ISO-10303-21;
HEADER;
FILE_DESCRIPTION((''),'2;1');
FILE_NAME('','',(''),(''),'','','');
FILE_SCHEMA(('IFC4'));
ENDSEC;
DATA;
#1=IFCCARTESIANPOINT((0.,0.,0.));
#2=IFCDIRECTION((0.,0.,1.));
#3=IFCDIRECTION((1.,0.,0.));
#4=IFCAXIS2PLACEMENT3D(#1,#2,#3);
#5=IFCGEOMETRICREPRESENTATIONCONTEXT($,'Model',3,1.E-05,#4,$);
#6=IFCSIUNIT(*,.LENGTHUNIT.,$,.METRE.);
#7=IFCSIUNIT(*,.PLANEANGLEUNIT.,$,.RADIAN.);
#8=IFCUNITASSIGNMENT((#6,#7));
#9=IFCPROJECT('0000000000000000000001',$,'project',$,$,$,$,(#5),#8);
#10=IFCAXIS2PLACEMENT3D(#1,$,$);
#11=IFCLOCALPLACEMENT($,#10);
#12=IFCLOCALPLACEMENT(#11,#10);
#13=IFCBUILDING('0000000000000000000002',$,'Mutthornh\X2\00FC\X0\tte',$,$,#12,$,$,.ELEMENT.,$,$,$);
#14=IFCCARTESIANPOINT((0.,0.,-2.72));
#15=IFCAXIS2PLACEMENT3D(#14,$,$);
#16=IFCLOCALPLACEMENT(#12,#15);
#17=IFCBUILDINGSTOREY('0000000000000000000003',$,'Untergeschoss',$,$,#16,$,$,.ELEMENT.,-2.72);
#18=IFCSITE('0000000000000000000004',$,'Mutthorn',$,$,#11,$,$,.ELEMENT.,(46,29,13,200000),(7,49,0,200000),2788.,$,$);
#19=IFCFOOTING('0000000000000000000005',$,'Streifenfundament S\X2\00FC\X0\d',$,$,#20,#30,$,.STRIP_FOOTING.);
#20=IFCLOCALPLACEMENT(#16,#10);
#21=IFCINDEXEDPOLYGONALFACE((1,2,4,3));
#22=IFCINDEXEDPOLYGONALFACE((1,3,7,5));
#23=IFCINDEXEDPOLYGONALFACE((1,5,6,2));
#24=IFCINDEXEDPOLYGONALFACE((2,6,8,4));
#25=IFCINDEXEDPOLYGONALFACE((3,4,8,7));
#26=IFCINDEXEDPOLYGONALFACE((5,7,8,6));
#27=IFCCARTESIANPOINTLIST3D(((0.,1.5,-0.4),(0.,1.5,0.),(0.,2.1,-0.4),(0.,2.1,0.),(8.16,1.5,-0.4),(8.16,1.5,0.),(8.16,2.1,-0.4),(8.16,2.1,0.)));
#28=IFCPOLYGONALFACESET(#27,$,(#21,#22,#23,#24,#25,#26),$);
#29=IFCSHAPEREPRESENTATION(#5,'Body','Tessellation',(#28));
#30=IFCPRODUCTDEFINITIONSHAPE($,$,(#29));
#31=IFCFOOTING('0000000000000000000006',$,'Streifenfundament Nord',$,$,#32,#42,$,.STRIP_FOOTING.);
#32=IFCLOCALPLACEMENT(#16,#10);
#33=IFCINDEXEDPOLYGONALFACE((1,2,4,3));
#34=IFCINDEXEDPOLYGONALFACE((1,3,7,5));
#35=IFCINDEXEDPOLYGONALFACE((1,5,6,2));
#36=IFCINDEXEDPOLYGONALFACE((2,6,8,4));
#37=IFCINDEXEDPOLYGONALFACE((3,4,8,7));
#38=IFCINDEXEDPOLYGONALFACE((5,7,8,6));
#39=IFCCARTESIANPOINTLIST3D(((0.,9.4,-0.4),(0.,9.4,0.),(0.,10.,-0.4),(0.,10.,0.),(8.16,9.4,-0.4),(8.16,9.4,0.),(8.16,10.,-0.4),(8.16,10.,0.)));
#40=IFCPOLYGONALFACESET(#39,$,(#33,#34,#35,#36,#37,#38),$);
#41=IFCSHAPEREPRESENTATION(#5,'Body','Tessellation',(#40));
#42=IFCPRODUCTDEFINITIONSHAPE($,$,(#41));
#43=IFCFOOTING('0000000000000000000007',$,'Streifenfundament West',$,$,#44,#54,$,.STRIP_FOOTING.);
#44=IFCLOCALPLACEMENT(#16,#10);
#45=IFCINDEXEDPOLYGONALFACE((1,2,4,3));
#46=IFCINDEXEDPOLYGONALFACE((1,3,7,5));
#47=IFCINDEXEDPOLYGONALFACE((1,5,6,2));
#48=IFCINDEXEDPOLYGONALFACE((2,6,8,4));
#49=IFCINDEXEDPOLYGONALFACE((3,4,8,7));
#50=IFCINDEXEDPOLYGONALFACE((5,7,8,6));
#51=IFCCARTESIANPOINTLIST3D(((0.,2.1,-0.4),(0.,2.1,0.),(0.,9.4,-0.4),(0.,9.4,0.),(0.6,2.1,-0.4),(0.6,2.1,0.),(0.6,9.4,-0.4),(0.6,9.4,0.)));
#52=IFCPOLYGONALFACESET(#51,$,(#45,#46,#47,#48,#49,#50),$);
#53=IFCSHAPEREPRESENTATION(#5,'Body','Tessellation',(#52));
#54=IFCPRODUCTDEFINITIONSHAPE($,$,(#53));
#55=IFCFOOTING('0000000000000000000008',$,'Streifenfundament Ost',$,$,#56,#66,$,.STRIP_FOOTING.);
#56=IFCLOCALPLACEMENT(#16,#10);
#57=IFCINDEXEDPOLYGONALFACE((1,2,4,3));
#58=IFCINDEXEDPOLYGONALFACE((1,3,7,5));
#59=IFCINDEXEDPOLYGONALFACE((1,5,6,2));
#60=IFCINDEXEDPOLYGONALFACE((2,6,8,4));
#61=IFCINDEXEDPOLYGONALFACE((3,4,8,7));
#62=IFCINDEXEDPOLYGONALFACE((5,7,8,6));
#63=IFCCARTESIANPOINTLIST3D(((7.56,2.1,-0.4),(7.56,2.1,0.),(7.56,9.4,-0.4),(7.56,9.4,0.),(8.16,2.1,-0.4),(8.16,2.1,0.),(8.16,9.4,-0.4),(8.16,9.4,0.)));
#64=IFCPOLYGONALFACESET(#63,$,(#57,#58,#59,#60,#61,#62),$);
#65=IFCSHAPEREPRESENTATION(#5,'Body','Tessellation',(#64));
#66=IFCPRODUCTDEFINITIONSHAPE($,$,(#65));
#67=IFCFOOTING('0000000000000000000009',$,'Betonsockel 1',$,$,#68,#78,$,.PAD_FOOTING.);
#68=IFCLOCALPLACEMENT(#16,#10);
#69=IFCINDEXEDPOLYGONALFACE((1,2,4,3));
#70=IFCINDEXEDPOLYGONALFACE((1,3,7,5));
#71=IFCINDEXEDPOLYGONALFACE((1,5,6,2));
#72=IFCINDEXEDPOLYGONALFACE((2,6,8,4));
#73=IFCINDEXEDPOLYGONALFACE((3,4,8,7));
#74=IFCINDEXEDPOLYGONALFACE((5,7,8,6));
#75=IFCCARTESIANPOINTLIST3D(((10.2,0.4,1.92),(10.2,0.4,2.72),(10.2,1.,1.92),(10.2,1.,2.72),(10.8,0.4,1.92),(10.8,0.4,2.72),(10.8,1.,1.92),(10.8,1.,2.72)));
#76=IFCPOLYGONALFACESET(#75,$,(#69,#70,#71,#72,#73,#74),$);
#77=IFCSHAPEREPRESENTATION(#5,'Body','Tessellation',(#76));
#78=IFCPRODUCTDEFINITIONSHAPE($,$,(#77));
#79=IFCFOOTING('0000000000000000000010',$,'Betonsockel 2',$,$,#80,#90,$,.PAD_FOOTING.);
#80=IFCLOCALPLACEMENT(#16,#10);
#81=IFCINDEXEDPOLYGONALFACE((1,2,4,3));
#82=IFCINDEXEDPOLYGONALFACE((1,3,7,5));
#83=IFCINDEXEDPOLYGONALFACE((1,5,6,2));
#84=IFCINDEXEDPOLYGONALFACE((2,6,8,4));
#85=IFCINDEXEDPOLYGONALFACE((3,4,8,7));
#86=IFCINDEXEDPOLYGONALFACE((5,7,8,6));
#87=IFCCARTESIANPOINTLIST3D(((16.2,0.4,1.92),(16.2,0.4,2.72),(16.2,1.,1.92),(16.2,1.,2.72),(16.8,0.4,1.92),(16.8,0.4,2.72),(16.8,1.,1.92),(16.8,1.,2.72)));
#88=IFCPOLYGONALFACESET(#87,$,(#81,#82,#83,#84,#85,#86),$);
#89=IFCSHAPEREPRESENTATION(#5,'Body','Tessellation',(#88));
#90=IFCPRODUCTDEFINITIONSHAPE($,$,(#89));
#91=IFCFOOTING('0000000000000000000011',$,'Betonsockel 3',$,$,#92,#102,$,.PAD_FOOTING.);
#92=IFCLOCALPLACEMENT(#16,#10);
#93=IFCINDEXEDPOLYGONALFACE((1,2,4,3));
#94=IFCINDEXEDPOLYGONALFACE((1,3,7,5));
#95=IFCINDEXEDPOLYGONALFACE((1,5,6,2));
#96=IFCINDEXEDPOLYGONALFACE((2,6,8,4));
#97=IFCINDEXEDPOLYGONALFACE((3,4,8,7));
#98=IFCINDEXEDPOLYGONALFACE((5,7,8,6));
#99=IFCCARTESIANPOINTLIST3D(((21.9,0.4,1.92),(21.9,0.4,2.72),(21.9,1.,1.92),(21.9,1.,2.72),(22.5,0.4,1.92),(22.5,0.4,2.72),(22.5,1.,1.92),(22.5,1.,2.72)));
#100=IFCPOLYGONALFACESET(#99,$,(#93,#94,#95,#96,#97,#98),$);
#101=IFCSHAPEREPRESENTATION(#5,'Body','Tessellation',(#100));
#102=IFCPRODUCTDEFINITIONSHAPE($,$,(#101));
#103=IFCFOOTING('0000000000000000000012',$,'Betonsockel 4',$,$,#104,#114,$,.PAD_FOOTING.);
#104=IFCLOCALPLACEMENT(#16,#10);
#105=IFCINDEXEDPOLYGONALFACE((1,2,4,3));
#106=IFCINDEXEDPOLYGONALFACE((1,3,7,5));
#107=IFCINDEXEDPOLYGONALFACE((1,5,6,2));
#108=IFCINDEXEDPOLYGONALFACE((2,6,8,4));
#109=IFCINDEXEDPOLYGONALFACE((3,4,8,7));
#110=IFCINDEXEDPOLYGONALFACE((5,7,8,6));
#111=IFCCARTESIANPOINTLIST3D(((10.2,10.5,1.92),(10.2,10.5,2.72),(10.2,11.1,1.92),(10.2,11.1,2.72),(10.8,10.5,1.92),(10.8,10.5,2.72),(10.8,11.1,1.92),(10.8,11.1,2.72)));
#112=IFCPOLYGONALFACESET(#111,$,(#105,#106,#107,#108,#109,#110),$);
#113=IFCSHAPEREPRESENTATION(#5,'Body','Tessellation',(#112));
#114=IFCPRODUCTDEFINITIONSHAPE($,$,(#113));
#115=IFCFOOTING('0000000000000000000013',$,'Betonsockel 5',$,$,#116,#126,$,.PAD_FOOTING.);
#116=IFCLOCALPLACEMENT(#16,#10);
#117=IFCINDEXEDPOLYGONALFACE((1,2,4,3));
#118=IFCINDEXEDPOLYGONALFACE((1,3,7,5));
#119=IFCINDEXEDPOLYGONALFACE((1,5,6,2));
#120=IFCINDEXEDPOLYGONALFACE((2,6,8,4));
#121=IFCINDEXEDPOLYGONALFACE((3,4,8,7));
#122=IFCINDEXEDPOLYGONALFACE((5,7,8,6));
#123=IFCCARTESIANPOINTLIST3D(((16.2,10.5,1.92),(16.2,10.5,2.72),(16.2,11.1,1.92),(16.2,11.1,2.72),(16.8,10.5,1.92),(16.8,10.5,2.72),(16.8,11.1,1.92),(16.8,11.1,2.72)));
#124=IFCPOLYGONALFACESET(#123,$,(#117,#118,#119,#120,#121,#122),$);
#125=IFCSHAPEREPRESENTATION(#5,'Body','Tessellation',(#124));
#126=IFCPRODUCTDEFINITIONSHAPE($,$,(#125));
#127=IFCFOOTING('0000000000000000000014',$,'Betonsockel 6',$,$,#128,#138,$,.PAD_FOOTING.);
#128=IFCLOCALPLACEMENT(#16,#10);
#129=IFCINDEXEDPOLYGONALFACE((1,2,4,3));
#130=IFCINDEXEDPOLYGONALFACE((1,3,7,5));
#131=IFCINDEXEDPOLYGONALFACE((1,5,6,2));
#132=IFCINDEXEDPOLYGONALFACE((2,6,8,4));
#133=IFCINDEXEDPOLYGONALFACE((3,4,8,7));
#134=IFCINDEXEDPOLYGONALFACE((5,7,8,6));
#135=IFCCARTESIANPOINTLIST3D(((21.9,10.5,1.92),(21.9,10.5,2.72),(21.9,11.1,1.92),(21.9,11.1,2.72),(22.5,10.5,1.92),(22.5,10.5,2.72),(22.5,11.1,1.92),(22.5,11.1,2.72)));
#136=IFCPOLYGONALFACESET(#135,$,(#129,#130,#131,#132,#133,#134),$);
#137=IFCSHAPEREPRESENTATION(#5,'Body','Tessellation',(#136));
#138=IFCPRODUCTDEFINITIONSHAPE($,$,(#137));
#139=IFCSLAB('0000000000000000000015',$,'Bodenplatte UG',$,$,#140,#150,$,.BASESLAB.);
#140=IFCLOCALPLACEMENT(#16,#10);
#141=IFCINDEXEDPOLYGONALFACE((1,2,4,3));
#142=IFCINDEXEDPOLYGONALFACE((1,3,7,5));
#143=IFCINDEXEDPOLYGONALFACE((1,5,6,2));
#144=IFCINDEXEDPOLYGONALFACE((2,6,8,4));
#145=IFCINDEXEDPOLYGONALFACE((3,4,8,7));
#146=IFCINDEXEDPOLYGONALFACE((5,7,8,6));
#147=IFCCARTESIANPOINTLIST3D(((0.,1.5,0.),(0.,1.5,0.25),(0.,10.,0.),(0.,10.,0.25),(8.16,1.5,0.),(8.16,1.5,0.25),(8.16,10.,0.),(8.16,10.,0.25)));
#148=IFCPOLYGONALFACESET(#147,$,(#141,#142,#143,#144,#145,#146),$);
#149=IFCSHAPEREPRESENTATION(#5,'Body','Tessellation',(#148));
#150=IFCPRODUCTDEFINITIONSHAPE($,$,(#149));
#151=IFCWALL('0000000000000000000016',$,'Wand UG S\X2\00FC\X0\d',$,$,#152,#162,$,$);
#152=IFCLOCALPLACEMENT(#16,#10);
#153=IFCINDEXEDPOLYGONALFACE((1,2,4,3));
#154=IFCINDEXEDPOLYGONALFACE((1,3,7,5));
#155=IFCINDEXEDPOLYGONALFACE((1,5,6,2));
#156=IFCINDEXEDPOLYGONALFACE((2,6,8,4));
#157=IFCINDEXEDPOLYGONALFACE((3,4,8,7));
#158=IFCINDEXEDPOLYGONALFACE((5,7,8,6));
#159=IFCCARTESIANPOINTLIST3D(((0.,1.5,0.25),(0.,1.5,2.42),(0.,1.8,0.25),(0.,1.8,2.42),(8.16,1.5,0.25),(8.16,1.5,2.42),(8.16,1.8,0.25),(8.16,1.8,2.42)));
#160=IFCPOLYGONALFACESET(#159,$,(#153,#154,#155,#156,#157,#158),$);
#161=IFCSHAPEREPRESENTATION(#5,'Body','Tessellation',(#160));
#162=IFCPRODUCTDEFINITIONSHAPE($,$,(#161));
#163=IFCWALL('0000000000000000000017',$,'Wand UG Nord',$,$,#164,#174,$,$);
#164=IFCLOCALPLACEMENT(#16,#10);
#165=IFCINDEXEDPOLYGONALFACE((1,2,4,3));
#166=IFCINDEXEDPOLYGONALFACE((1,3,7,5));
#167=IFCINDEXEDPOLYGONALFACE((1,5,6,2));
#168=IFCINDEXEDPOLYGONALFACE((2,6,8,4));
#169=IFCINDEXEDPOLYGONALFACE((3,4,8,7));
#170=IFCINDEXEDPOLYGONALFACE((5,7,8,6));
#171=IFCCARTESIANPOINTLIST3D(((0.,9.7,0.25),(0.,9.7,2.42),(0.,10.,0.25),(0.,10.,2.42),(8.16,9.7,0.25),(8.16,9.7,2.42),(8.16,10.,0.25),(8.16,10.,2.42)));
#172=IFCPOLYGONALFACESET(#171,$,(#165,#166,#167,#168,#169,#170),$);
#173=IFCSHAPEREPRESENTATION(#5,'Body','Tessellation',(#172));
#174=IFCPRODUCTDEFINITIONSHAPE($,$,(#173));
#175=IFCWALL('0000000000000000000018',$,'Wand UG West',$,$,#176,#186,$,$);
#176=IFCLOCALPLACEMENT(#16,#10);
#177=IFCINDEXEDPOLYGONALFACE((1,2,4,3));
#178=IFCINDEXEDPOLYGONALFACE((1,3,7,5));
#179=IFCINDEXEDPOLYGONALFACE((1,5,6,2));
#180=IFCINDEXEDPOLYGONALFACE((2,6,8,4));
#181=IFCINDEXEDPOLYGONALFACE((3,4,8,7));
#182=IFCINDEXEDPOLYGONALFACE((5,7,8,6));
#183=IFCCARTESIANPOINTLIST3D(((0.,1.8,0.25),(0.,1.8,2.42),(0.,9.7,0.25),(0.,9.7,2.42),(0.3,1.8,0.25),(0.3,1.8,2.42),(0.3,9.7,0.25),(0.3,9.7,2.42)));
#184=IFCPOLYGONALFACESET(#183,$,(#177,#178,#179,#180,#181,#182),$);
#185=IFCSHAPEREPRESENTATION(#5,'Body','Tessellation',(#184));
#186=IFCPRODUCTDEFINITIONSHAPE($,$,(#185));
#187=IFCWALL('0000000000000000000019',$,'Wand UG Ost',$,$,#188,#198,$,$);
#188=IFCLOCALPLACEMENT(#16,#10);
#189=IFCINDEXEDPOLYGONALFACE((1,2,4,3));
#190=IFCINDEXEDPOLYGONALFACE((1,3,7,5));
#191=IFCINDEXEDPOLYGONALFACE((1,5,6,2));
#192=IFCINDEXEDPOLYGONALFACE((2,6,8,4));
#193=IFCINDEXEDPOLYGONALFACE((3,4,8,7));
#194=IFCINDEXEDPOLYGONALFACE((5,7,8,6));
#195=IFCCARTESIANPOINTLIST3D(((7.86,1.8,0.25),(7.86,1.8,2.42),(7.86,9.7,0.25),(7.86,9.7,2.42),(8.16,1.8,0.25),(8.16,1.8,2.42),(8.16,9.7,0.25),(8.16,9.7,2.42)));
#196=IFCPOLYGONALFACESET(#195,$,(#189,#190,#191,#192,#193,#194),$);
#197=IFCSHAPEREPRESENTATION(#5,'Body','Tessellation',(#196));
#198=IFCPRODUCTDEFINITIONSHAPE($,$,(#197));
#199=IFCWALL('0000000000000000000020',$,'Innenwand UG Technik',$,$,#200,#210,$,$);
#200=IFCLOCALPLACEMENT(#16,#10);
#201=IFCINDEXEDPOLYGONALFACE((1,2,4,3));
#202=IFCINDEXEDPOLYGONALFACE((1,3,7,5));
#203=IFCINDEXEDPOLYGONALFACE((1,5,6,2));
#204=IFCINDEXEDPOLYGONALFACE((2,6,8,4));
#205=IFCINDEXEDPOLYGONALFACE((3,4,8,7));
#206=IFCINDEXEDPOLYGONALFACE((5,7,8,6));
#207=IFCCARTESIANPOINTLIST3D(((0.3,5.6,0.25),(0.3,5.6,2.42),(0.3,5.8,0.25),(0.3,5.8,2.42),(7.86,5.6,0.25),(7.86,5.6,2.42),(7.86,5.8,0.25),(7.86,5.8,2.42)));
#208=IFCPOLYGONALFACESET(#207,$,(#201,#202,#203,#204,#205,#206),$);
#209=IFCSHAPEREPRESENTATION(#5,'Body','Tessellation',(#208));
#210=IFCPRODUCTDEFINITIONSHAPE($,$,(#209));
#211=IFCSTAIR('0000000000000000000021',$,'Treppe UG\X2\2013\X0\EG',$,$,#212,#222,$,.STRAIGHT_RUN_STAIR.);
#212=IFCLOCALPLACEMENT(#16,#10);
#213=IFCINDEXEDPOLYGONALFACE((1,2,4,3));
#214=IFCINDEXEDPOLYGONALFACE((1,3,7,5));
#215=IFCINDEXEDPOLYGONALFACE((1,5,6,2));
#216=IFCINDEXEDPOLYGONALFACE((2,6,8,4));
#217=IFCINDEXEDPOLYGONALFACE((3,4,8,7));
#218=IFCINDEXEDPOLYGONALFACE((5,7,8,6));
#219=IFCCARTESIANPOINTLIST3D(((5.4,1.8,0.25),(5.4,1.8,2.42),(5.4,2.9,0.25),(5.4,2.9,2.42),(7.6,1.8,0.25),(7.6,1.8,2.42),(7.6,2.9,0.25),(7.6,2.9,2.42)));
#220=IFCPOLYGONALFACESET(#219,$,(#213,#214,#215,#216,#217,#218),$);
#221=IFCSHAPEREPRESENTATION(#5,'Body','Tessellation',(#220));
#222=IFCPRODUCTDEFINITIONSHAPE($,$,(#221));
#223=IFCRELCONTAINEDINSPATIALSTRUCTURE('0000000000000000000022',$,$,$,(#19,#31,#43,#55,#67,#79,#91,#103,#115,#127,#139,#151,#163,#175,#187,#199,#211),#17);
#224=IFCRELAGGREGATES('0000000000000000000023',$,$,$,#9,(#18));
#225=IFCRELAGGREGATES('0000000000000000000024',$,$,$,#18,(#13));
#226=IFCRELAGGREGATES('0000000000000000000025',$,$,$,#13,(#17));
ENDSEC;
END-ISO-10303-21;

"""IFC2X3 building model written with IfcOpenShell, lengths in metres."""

from ifc_helpers import new_model, si_unit, frame, frame_2d, origin, origin_with_axes, place, context, project, spatial, rectangle, extrude, element, save


model = new_model("IFC2X3")

# Units and contexts
model_context = context("Model", 3, precision=1e-05, world=origin_with_axes())
ifc_project = project(units=[si_unit("LENGTHUNIT", "METRE"), si_unit("PLANEANGLEUNIT", "RADIAN")], contexts=[model_context])

# Site, building, storey
site_placement = place(None, origin())
site = spatial("IfcSite", under=ifc_project, at=site_placement, Name="Mutthorn", CompositionType="ELEMENT", RefLatitude=(46, 29, 13, 200000), RefLongitude=(7, 49, 0, 200000), RefElevation=2788.0)
building_placement = place(site_placement, origin())
building = spatial("IfcBuilding", under=site, at=building_placement, Name="Mutthornhütte", CompositionType="ELEMENT")
storey_placement = place(building_placement, frame((0.0, 0.0, -2.72)))
storey = spatial("IfcBuildingStorey", under=building, at=storey_placement, Name="Untergeschoss", CompositionType="ELEMENT", Elevation=-2.72)

# Footings
footing_1_placement = place(storey_placement, origin())
element("IfcFooting", 1, at=footing_1_placement, inside=storey, Name="Streifenfundament Süd", PredefinedType="STRIP_FOOTING", context=model_context, shape_type="SweptSolid", body=[
    extrude(rectangle(XDim=8.16, YDim=0.6, at=frame_2d((4.08, 0.3))), frame((0.0, 1.5, -0.4)), (0.0, 0.0, 1.0), 0.4),
])
footing_2_placement = place(storey_placement, origin())
element("IfcFooting", 2, at=footing_2_placement, inside=storey, Name="Streifenfundament Nord", PredefinedType="STRIP_FOOTING", context=model_context, shape_type="SweptSolid", body=[
    extrude(rectangle(XDim=8.16, YDim=0.6, at=frame_2d((4.08, 0.3))), frame((0.0, 9.4, -0.4)), (0.0, 0.0, 1.0), 0.4),
])
footing_3_placement = place(storey_placement, origin())
element("IfcFooting", 3, at=footing_3_placement, inside=storey, Name="Streifenfundament West", PredefinedType="STRIP_FOOTING", context=model_context, shape_type="SweptSolid", body=[
    extrude(rectangle(XDim=0.6, YDim=7.3, at=frame_2d((0.3, 3.65))), frame((0.0, 2.1, -0.4)), (0.0, 0.0, 1.0), 0.4),
])
footing_4_placement = place(storey_placement, origin())
element("IfcFooting", 4, at=footing_4_placement, inside=storey, Name="Streifenfundament Ost", PredefinedType="STRIP_FOOTING", context=model_context, shape_type="SweptSolid", body=[
    extrude(rectangle(XDim=0.6, YDim=7.3, at=frame_2d((0.3, 3.65))), frame((7.56, 2.1, -0.4)), (0.0, 0.0, 1.0), 0.4),
])
footing_5_placement = place(storey_placement, origin())
element("IfcFooting", 5, at=footing_5_placement, inside=storey, Name="Betonsockel 1", PredefinedType="PAD_FOOTING", context=model_context, shape_type="SweptSolid", body=[
    extrude(rectangle(XDim=0.6, YDim=0.6, at=frame_2d((0.3, 0.3))), frame((10.2, 0.4, 1.92)), (0.0, 0.0, 1.0), 0.8),
])
footing_6_placement = place(storey_placement, origin())
element("IfcFooting", 6, at=footing_6_placement, inside=storey, Name="Betonsockel 2", PredefinedType="PAD_FOOTING", context=model_context, shape_type="SweptSolid", body=[
    extrude(rectangle(XDim=0.6, YDim=0.6, at=frame_2d((0.3, 0.3))), frame((16.2, 0.4, 1.92)), (0.0, 0.0, 1.0), 0.8),
])
footing_7_placement = place(storey_placement, origin())
element("IfcFooting", 7, at=footing_7_placement, inside=storey, Name="Betonsockel 3", PredefinedType="PAD_FOOTING", context=model_context, shape_type="SweptSolid", body=[
    extrude(rectangle(XDim=0.6, YDim=0.6, at=frame_2d((0.3, 0.3))), frame((21.9, 0.4, 1.92)), (0.0, 0.0, 1.0), 0.8),
])
footing_8_placement = place(storey_placement, origin())
element("IfcFooting", 8, at=footing_8_placement, inside=storey, Name="Betonsockel 4", PredefinedType="PAD_FOOTING", context=model_context, shape_type="SweptSolid", body=[
    extrude(rectangle(XDim=0.6, YDim=0.6, at=frame_2d((0.3, 0.3))), frame((10.2, 10.5, 1.92)), (0.0, 0.0, 1.0), 0.8),
])
footing_9_placement = place(storey_placement, origin())
element("IfcFooting", 9, at=footing_9_placement, inside=storey, Name="Betonsockel 5", PredefinedType="PAD_FOOTING", context=model_context, shape_type="SweptSolid", body=[
    extrude(rectangle(XDim=0.6, YDim=0.6, at=frame_2d((0.3, 0.3))), frame((16.2, 10.5, 1.92)), (0.0, 0.0, 1.0), 0.8),
])
footing_10_placement = place(storey_placement, origin())
element("IfcFooting", 10, at=footing_10_placement, inside=storey, Name="Betonsockel 6", PredefinedType="PAD_FOOTING", context=model_context, shape_type="SweptSolid", body=[
    extrude(rectangle(XDim=0.6, YDim=0.6, at=frame_2d((0.3, 0.3))), frame((21.9, 10.5, 1.92)), (0.0, 0.0, 1.0), 0.8),
])

# Slab
slab_placement = place(storey_placement, origin())
element("IfcSlab", 11, at=slab_placement, inside=storey, Name="Bodenplatte UG", PredefinedType="BASESLAB", context=model_context, shape_type="SweptSolid", body=[
    extrude(rectangle(XDim=8.16, YDim=8.5, at=frame_2d((4.08, 4.25))), frame((0.0, 1.5, 0.0)), (0.0, 0.0, 1.0), 0.25),
])

# Walls
wall_1_placement = place(storey_placement, origin())
element("IfcWall", 12, at=wall_1_placement, inside=storey, Name="Wand UG Süd", context=model_context, shape_type="SweptSolid", body=[
    extrude(rectangle(XDim=8.16, YDim=0.3, at=frame_2d((4.08, 0.15))), frame((0.0, 1.5, 0.25)), (0.0, 0.0, 1.0), 2.17),
])
wall_2_placement = place(storey_placement, origin())
element("IfcWall", 13, at=wall_2_placement, inside=storey, Name="Wand UG Nord", context=model_context, shape_type="SweptSolid", body=[
    extrude(rectangle(XDim=8.16, YDim=0.3, at=frame_2d((4.08, 0.15))), frame((0.0, 9.7, 0.25)), (0.0, 0.0, 1.0), 2.17),
])
wall_3_placement = place(storey_placement, origin())
element("IfcWall", 14, at=wall_3_placement, inside=storey, Name="Wand UG West", context=model_context, shape_type="SweptSolid", body=[
    extrude(rectangle(XDim=0.3, YDim=7.9, at=frame_2d((0.15, 3.95))), frame((0.0, 1.8, 0.25)), (0.0, 0.0, 1.0), 2.17),
])
wall_4_placement = place(storey_placement, origin())
element("IfcWall", 15, at=wall_4_placement, inside=storey, Name="Wand UG Ost", context=model_context, shape_type="SweptSolid", body=[
    extrude(rectangle(XDim=0.3, YDim=7.9, at=frame_2d((0.15, 3.95))), frame((7.86, 1.8, 0.25)), (0.0, 0.0, 1.0), 2.17),
])
wall_5_placement = place(storey_placement, origin())
element("IfcWall", 16, at=wall_5_placement, inside=storey, Name="Innenwand UG Technik", context=model_context, shape_type="SweptSolid", body=[
    extrude(rectangle(XDim=7.56, YDim=0.2, at=frame_2d((3.78, 0.1))), frame((0.3, 5.6, 0.25)), (0.0, 0.0, 1.0), 2.17),
])

# Stair
stair_placement = place(storey_placement, origin())
element("IfcStair", 17, at=stair_placement, inside=storey, Name="Treppe UG–EG", ShapeType="STRAIGHT_RUN_STAIR", context=model_context, shape_type="SweptSolid", body=[
    extrude(rectangle(XDim=2.2, YDim=1.1, at=frame_2d((1.1, 0.55))), frame((5.4, 1.8, 0.25)), (0.0, 0.0, 1.0), 2.17),
])

save(model, "model.ifc")
